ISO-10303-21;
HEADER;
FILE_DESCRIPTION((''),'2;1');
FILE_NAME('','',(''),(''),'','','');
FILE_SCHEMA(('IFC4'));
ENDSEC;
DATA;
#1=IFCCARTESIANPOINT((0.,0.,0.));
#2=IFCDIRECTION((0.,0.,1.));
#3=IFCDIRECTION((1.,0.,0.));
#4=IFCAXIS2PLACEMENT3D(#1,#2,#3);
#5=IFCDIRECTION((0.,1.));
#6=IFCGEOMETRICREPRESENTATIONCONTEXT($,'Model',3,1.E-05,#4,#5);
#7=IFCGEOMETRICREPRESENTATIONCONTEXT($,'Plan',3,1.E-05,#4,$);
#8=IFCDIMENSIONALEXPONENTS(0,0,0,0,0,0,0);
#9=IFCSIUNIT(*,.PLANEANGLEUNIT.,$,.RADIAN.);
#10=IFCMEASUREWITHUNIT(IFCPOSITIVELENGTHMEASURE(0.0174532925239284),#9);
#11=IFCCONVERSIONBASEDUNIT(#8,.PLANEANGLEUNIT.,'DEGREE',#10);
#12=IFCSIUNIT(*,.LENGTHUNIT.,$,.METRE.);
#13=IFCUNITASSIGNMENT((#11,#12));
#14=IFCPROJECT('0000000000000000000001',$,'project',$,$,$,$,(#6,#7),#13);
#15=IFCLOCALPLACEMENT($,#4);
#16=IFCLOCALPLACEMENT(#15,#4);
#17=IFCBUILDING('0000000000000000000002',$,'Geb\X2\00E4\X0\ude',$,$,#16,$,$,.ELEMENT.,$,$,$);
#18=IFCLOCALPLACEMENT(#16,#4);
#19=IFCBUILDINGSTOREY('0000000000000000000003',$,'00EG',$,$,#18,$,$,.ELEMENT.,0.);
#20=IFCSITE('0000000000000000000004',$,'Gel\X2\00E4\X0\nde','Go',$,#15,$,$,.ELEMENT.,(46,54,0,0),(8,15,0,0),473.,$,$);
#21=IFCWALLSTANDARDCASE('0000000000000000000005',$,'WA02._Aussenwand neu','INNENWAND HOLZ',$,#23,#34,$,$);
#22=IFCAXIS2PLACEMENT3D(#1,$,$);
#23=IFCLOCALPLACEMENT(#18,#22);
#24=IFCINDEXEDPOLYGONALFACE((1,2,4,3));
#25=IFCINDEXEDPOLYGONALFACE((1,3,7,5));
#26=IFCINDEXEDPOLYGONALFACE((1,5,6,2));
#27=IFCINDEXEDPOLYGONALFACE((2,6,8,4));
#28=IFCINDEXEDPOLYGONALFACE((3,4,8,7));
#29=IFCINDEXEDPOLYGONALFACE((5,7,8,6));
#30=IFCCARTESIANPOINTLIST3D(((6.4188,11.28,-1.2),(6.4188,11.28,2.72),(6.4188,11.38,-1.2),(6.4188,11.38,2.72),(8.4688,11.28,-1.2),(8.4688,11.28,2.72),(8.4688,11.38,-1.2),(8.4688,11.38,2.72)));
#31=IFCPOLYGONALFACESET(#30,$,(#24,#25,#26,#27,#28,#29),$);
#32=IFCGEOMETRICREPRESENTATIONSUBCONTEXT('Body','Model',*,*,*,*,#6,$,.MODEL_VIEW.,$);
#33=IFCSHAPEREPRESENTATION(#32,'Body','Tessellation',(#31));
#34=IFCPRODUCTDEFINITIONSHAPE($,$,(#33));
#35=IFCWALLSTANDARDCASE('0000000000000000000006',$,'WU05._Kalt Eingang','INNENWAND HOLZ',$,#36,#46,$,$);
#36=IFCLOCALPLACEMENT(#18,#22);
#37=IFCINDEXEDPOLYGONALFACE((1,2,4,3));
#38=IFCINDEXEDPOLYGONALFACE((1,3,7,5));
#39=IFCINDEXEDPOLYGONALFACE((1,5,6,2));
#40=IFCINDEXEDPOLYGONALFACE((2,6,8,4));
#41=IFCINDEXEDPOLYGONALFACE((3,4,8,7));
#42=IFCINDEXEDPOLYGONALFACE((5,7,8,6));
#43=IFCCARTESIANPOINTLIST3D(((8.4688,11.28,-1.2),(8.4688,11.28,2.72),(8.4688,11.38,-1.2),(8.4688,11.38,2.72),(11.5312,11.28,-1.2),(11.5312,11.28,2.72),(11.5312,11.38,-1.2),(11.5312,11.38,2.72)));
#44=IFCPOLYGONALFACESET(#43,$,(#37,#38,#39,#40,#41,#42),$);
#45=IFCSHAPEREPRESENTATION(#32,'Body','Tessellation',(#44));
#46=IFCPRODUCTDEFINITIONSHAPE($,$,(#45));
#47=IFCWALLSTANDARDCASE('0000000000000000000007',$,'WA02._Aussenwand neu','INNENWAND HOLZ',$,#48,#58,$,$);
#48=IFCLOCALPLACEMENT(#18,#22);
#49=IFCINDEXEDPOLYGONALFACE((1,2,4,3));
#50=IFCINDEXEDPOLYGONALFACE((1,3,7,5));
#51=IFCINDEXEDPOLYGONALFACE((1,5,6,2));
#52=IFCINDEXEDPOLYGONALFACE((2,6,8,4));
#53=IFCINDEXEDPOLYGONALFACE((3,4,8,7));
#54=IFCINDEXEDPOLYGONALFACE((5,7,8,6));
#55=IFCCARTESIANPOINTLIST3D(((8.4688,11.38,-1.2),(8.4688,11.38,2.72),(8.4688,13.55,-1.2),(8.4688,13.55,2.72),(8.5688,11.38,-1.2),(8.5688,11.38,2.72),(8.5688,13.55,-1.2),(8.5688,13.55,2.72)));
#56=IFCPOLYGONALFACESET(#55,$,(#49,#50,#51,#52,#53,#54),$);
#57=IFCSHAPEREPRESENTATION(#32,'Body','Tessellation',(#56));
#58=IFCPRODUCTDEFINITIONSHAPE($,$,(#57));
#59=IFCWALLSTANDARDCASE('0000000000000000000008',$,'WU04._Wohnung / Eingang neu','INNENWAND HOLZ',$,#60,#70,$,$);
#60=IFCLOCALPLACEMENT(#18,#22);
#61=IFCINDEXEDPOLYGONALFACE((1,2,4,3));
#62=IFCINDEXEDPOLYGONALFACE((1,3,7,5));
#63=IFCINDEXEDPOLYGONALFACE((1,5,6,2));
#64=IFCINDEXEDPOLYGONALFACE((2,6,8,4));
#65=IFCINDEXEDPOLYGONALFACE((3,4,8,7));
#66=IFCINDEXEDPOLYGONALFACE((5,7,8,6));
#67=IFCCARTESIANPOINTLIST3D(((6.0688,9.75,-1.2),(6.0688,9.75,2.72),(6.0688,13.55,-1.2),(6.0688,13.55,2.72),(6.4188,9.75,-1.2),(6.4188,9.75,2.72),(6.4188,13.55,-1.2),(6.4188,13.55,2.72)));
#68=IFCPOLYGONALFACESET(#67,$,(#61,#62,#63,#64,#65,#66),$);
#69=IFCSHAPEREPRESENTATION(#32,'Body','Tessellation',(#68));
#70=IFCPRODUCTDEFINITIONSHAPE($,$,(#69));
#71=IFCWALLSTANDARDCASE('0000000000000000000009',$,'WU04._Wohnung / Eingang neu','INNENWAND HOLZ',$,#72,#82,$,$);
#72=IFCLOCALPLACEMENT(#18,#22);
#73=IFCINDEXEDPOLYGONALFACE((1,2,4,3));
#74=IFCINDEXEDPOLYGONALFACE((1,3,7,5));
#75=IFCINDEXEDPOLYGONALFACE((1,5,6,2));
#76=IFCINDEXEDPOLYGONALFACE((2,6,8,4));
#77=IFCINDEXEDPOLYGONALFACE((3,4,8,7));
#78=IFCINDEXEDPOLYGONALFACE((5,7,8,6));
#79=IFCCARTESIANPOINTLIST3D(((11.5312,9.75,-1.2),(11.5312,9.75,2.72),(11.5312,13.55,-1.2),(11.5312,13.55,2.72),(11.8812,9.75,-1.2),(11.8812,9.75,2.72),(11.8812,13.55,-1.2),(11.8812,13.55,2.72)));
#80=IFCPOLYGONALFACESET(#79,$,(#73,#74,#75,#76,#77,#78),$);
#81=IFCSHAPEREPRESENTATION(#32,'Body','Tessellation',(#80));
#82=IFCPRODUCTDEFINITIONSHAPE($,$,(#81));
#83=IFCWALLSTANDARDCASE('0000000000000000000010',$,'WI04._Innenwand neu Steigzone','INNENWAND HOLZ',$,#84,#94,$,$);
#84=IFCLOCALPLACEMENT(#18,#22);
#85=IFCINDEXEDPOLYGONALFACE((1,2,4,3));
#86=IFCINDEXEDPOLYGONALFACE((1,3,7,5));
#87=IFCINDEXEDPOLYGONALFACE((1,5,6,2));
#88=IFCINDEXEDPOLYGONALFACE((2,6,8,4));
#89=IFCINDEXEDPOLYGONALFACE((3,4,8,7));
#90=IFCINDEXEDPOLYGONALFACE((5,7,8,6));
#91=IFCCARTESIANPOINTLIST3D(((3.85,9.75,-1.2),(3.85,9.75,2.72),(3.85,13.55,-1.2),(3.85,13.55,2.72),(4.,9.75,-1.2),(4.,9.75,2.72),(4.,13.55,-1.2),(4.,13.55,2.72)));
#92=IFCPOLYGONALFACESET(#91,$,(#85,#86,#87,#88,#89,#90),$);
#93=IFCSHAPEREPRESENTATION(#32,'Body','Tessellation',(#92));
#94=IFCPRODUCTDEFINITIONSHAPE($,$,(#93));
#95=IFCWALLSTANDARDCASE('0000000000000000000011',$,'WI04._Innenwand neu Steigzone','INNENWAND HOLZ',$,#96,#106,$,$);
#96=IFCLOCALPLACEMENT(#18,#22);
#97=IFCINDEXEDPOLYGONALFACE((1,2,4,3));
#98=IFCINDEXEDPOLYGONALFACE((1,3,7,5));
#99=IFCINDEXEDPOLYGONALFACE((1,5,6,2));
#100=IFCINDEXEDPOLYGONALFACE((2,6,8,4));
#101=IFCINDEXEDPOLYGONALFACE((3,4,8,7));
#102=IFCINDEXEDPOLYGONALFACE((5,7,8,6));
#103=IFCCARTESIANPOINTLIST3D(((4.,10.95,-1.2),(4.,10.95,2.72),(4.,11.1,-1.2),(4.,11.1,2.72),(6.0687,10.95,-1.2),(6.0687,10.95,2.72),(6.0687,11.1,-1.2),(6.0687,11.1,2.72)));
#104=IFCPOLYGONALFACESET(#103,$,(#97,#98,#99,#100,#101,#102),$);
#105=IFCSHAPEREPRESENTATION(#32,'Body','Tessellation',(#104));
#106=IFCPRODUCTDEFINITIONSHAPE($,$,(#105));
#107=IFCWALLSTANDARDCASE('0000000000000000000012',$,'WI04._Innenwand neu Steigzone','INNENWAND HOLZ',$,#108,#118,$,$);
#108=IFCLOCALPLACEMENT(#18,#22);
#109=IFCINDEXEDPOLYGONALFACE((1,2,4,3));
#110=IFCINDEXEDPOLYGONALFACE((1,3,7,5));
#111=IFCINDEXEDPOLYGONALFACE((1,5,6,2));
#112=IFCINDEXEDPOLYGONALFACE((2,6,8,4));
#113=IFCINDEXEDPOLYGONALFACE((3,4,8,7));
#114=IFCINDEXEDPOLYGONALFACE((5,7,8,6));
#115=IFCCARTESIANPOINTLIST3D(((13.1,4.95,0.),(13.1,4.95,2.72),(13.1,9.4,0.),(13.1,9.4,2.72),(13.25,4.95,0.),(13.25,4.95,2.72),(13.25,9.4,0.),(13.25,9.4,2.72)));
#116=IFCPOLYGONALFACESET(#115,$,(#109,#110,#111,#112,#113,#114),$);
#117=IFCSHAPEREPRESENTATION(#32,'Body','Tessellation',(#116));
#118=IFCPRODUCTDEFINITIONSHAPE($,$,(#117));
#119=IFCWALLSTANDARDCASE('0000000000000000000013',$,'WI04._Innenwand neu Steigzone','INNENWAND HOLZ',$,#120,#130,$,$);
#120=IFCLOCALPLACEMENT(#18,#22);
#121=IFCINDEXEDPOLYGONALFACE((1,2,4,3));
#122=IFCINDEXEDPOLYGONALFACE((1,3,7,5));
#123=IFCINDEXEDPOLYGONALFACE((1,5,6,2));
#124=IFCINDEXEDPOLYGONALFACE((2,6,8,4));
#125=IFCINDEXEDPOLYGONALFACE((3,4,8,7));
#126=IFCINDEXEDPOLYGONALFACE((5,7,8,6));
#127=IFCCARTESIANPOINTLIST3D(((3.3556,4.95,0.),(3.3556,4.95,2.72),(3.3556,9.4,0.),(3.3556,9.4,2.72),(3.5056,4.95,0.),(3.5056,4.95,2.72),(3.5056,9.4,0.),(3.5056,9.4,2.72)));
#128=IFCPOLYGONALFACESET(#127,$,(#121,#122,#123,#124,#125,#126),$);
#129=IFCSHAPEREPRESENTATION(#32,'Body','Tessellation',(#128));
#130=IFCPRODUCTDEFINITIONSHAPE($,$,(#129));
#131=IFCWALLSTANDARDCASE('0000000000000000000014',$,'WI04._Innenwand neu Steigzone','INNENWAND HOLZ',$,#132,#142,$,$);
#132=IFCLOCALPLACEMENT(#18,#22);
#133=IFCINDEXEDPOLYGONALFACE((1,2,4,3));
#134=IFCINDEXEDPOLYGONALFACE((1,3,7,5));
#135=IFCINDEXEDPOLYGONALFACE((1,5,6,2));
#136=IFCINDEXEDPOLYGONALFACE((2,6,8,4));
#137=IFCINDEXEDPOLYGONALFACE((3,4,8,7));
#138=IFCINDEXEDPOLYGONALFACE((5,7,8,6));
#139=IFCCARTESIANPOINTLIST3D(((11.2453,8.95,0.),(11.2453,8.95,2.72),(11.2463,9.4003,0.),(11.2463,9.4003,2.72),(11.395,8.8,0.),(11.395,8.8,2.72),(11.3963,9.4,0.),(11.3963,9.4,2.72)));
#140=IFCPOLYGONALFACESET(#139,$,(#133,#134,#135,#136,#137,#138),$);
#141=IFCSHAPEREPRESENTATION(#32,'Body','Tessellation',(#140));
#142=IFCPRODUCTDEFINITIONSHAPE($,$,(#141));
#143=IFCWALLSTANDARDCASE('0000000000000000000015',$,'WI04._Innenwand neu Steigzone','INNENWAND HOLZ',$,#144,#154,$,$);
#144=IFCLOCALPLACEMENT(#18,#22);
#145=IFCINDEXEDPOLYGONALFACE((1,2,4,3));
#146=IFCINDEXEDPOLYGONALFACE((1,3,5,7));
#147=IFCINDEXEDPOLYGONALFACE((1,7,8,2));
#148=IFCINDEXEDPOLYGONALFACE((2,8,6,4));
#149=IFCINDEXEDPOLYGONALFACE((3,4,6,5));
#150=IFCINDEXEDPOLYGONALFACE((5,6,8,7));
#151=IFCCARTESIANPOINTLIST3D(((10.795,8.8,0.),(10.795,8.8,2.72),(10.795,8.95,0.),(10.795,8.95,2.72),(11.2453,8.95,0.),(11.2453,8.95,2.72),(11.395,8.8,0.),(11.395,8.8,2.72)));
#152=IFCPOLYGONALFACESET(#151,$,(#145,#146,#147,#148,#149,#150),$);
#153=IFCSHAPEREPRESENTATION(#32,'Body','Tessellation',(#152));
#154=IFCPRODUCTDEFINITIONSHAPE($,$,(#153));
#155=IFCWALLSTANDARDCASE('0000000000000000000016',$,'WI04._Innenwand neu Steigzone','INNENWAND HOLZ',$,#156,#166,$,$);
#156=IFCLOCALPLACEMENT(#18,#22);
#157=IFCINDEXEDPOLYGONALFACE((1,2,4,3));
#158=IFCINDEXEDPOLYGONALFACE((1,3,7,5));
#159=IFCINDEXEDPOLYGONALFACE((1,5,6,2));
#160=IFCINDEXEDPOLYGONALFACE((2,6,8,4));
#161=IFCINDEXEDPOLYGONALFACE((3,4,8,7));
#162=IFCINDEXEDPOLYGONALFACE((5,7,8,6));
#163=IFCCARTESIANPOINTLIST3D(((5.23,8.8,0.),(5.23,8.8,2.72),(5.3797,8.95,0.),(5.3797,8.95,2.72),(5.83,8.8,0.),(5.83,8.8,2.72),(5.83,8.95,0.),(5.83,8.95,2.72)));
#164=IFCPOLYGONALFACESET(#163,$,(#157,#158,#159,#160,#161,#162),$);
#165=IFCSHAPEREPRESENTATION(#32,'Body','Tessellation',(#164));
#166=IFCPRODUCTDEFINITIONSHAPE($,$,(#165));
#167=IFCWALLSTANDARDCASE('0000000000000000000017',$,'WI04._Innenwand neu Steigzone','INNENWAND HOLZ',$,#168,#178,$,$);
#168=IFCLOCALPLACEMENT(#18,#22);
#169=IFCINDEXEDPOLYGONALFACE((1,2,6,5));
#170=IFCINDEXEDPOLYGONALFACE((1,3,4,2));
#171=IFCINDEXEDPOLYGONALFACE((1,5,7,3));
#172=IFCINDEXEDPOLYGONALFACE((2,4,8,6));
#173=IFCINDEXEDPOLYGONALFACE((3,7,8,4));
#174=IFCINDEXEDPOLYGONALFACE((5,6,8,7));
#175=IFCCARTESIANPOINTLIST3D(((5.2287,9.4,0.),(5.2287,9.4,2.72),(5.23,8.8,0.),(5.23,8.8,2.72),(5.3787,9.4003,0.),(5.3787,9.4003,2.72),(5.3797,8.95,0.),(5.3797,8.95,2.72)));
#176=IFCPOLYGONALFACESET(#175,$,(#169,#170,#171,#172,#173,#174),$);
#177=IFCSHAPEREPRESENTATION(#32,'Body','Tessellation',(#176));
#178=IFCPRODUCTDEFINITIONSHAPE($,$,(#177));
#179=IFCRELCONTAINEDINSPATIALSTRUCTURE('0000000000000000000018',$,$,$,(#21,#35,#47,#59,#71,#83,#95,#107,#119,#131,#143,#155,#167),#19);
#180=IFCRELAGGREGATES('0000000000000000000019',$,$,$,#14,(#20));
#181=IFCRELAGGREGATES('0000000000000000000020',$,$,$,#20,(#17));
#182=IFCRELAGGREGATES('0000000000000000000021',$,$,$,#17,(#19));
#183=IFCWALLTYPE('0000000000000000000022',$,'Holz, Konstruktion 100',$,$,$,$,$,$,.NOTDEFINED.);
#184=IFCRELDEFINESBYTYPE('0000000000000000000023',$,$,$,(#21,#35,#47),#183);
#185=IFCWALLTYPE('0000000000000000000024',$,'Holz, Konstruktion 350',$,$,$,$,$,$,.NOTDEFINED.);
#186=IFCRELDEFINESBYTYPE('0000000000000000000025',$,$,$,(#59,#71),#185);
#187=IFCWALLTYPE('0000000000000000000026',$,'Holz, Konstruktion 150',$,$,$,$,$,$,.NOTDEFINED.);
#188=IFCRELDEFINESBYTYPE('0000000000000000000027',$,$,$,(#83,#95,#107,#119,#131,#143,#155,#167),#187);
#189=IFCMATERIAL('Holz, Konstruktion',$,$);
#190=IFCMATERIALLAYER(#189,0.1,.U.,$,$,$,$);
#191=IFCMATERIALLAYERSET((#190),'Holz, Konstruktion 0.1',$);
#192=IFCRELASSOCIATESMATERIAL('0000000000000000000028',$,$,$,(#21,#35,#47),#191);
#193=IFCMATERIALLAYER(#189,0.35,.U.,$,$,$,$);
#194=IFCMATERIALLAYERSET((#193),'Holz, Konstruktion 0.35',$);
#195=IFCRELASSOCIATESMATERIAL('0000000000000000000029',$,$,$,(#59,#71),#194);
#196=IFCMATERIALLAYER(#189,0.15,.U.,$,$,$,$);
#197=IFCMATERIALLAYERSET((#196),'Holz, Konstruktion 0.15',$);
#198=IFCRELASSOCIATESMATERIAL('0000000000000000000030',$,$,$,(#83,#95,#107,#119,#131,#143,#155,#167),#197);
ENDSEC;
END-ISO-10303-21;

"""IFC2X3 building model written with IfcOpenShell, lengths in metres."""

from ifc_helpers import new_model, entity, si_unit, converted_unit, direction, frame, origin_with_axes, place, context, subcontext, project, spatial, polyline, outline, extrude, material, layer, layer_set, layer_usage, type_object, element, save


model = new_model("IFC2X3")

# Units and contexts
model_context = context("Model", 3, precision=1e-05, world=origin_with_axes(), true_north=direction((0.0, 1.0)))
plan_context = context("Plan", 3, precision=1e-05, world=origin_with_axes())
body_context = subcontext(model_context, "Body", "Model", "MODEL_VIEW")
ifc_project = project(units=[converted_unit("PLANEANGLEUNIT", "DEGREE", entity("IfcPositiveLengthMeasure", 0.0174532925239284), si_unit("PLANEANGLEUNIT", "RADIAN"), dimensions=[0, 0, 0, 0, 0, 0, 0]), si_unit("LENGTHUNIT", "METRE")], contexts=[model_context, plan_context])

# Site, building, storey
site_placement = place(None, origin_with_axes())
site = spatial("IfcSite", under=ifc_project, at=site_placement, Name="Gelände", Description="Go", CompositionType="ELEMENT", RefLatitude=(46, 54, 0, 0), RefLongitude=(8, 15, 0, 0), RefElevation=473.0)
building_placement = place(site_placement, origin_with_axes())
building = spatial("IfcBuilding", under=site, at=building_placement, Name="Gebäude", CompositionType="ELEMENT")
storey_placement = place(building_placement, origin_with_axes())
storey = spatial("IfcBuildingStorey", under=building, at=storey_placement, Name="00EG", CompositionType="ELEMENT", Elevation=0.0)

# Shared definitions
ifc_material_1 = material(Name="Holz, Konstruktion")

# Walls
ifc_layer_1 = layer(ifc_material_1, 0.1, ventilated="UNKNOWN")
ifc_layer_set_1 = layer_set([ifc_layer_1], Name="Holz, Konstruktion 0.1")
ifc_layer_usage_1 = layer_usage(ifc_layer_set_1, "AXIS2", "POSITIVE", 0.0)
wall_type_1 = type_object("IfcWallType", Name="Holz, Konstruktion 100", PredefinedType="NOTDEFINED")
wall_1_placement = place(storey_placement, frame((6.4188, 11.28, -1.2), z_axis=(0.0, 0.0, 1.0), x_axis=(1.0, 0.0, 0.0)))
element("IfcWallStandardCase", 1, at=wall_1_placement, inside=storey, type_object=wall_type_1, material=ifc_layer_usage_1, Name="WA02._Aussenwand neu", Description="INNENWAND HOLZ", context=body_context, shape_type="SweptSolid", body=[
    extrude(outline(polyline([(0.0, 0.0), (2.05, 0.0), (2.05, 0.1), (0.0, 0.1), (0.0, 0.0)])), origin_with_axes(), (0.0, 0.0, 1.0), 3.92),
])
ifc_layer_usage_2 = layer_usage(ifc_layer_set_1, "AXIS2", "POSITIVE", 0.0)
wall_2_placement = place(storey_placement, frame((8.4688, 11.28, -1.2), z_axis=(0.0, 0.0, 1.0), x_axis=(1.0, 0.0, 0.0)))
element("IfcWallStandardCase", 2, at=wall_2_placement, inside=storey, type_object=wall_type_1, material=ifc_layer_usage_2, Name="WU05._Kalt Eingang", Description="INNENWAND HOLZ", context=body_context, shape_type="SweptSolid", body=[
    extrude(outline(polyline([(0.0, 0.0), (3.0625, 0.0), (3.0625, 0.1), (0.0, 0.1), (0.0, 0.0)])), origin_with_axes(), (0.0, 0.0, 1.0), 3.92),
])
ifc_layer_usage_3 = layer_usage(ifc_layer_set_1, "AXIS2", "POSITIVE", 0.0)
wall_3_placement = place(storey_placement, frame((8.4688, 13.55, -1.2), z_axis=(0.0, 0.0, 1.0), x_axis=(0.0, -1.0, 0.0)))
element("IfcWallStandardCase", 3, at=wall_3_placement, inside=storey, type_object=wall_type_1, material=ifc_layer_usage_3, Name="WA02._Aussenwand neu", Description="INNENWAND HOLZ", context=body_context, shape_type="SweptSolid", body=[
    extrude(outline(polyline([(0.0, 0.0), (2.17, 0.0), (2.17, 0.1), (0.0, 0.1), (0.0, 0.0)])), origin_with_axes(), (0.0, 0.0, 1.0), 3.92),
])
ifc_layer_2 = layer(ifc_material_1, 0.35, ventilated="UNKNOWN")
ifc_layer_set_2 = layer_set([ifc_layer_2], Name="Holz, Konstruktion 0.35")
ifc_layer_usage_4 = layer_usage(ifc_layer_set_2, "AXIS2", "NEGATIVE", 0.0)
wall_type_2 = type_object("IfcWallType", Name="Holz, Konstruktion 350", PredefinedType="NOTDEFINED")
wall_4_placement = place(storey_placement, frame((6.4188, 13.55, -1.2), z_axis=(0.0, 0.0, 1.0), x_axis=(0.0, -1.0, 0.0)))
element("IfcWallStandardCase", 4, at=wall_4_placement, inside=storey, type_object=wall_type_2, material=ifc_layer_usage_4, Name="WU04._Wohnung / Eingang neu", Description="INNENWAND HOLZ", context=body_context, shape_type="SweptSolid", body=[
    extrude(outline(polyline([(0.0, -0.35), (3.8, -0.35), (3.8, 0.0), (0.0, 0.0), (0.0, -0.35)])), origin_with_axes(), (0.0, 0.0, 1.0), 3.92),
])
ifc_layer_usage_5 = layer_usage(ifc_layer_set_2, "AXIS2", "NEGATIVE", 0.0)
wall_5_placement = place(storey_placement, frame((11.8812, 13.55, -1.2), z_axis=(0.0, 0.0, 1.0), x_axis=(0.0, -1.0, 0.0)))
element("IfcWallStandardCase", 5, at=wall_5_placement, inside=storey, type_object=wall_type_2, material=ifc_layer_usage_5, Name="WU04._Wohnung / Eingang neu", Description="INNENWAND HOLZ", context=body_context, shape_type="SweptSolid", body=[
    extrude(outline(polyline([(0.0, -0.35), (3.8, -0.35), (3.8, 0.0), (0.0, 0.0), (0.0, -0.35)])), origin_with_axes(), (0.0, 0.0, 1.0), 3.92),
])
ifc_layer_3 = layer(ifc_material_1, 0.15, ventilated="UNKNOWN")
ifc_layer_set_3 = layer_set([ifc_layer_3], Name="Holz, Konstruktion 0.15")
ifc_layer_usage_6 = layer_usage(ifc_layer_set_3, "AXIS2", "NEGATIVE", 0.0)
wall_type_3 = type_object("IfcWallType", Name="Holz, Konstruktion 150", PredefinedType="NOTDEFINED")
wall_6_placement = place(storey_placement, frame((4.0, 13.55, -1.2), z_axis=(0.0, 0.0, 1.0), x_axis=(0.0, -1.0, 0.0)))
element("IfcWallStandardCase", 6, at=wall_6_placement, inside=storey, type_object=wall_type_3, material=ifc_layer_usage_6, Name="WI04._Innenwand neu Steigzone", Description="INNENWAND HOLZ", context=body_context, shape_type="SweptSolid", body=[
    extrude(outline(polyline([(0.0, -0.15), (3.8, -0.15), (3.8, 0.0), (0.0, 0.0), (0.0, -0.15)])), origin_with_axes(), (0.0, 0.0, 1.0), 3.92),
])
ifc_layer_usage_7 = layer_usage(ifc_layer_set_3, "AXIS2", "NEGATIVE", 0.0)
wall_7_placement = place(storey_placement, frame((6.0687, 10.95, -1.2), z_axis=(0.0, 0.0, 1.0), x_axis=(-1.0, 0.0, 0.0)))
element("IfcWallStandardCase", 7, at=wall_7_placement, inside=storey, type_object=wall_type_3, material=ifc_layer_usage_7, Name="WI04._Innenwand neu Steigzone", Description="INNENWAND HOLZ", context=body_context, shape_type="SweptSolid", body=[
    extrude(outline(polyline([(0.0, -0.15), (2.0687, -0.15), (2.0687, 0.0), (0.0, 0.0), (0.0, -0.15)])), origin_with_axes(), (0.0, 0.0, 1.0), 3.92),
])
ifc_layer_usage_8 = layer_usage(ifc_layer_set_3, "AXIS2", "POSITIVE", 0.0)
wall_8_placement = place(storey_placement, frame((13.1, 9.4, 0.0), z_axis=(0.0, 0.0, 1.0), x_axis=(0.0, -1.0, 0.0)))
element("IfcWallStandardCase", 8, at=wall_8_placement, inside=storey, type_object=wall_type_3, material=ifc_layer_usage_8, Name="WI04._Innenwand neu Steigzone", Description="INNENWAND HOLZ", context=body_context, shape_type="SweptSolid", body=[
    extrude(outline(polyline([(0.0, 0.0), (4.45, 0.0), (4.45, 0.15), (0.0, 0.15), (0.0, 0.0)])), origin_with_axes(), (0.0, 0.0, 1.0), 2.72),
])
ifc_layer_usage_9 = layer_usage(ifc_layer_set_3, "AXIS2", "NEGATIVE", 0.0)
wall_9_placement = place(storey_placement, frame((3.5056, 9.4, 0.0), z_axis=(0.0, 0.0, 1.0), x_axis=(0.0, -1.0, 0.0)))
element("IfcWallStandardCase", 9, at=wall_9_placement, inside=storey, type_object=wall_type_3, material=ifc_layer_usage_9, Name="WI04._Innenwand neu Steigzone", Description="INNENWAND HOLZ", context=body_context, shape_type="SweptSolid", body=[
    extrude(outline(polyline([(0.0, -0.15), (4.45, -0.15), (4.45, 0.0), (0.0, 0.0), (0.0, -0.15)])), origin_with_axes(), (0.0, 0.0, 1.0), 2.72),
])
ifc_layer_usage_10 = layer_usage(ifc_layer_set_3, "AXIS2", "NEGATIVE", 0.0)
wall_10_placement = place(storey_placement, frame((11.3963, 9.4, 0.0), z_axis=(0.0, 0.0, 1.0), x_axis=(-0.002118, -0.999998, 0.0)))
element("IfcWallStandardCase", 10, at=wall_10_placement, inside=storey, type_object=wall_type_3, material=ifc_layer_usage_10, Name="WI04._Innenwand neu Steigzone", Description="INNENWAND HOLZ", context=body_context, shape_type="SweptSolid", body=[
    extrude(outline(polyline([(0.0, -0.15), (0.4503, -0.15), (0.6, 0.0), (0.0, 0.0), (0.0, -0.15)])), origin_with_axes(), (0.0, 0.0, 1.0), 2.72),
])
ifc_layer_usage_11 = layer_usage(ifc_layer_set_3, "AXIS2", "NEGATIVE", 0.0)
wall_11_placement = place(storey_placement, frame((11.395, 8.8, 0.0), z_axis=(0.0, 0.0, 1.0), x_axis=(-1.0, 0.0, 0.0)))
element("IfcWallStandardCase", 11, at=wall_11_placement, inside=storey, type_object=wall_type_3, material=ifc_layer_usage_11, Name="WI04._Innenwand neu Steigzone", Description="INNENWAND HOLZ", context=body_context, shape_type="SweptSolid", body=[
    extrude(outline(polyline([(0.1497, -0.15), (0.6, -0.15), (0.6, 0.0), (0.0, 0.0), (0.1497, -0.15)])), origin_with_axes(), (0.0, 0.0, 1.0), 2.72),
])
ifc_layer_usage_12 = layer_usage(ifc_layer_set_3, "AXIS2", "POSITIVE", 0.0)
wall_12_placement = place(storey_placement, frame((5.23, 8.8, 0.0), z_axis=(0.0, 0.0, 1.0), x_axis=(1.0, 0.0, 0.0)))
element("IfcWallStandardCase", 12, at=wall_12_placement, inside=storey, type_object=wall_type_3, material=ifc_layer_usage_12, Name="WI04._Innenwand neu Steigzone", Description="INNENWAND HOLZ", context=body_context, shape_type="SweptSolid", body=[
    extrude(outline(polyline([(0.0, 0.0), (0.6, 0.0), (0.6, 0.15), (0.1497, 0.15), (0.0, 0.0)])), origin_with_axes(), (0.0, 0.0, 1.0), 2.72),
])
ifc_layer_usage_13 = layer_usage(ifc_layer_set_3, "AXIS2", "POSITIVE", 0.0)
wall_13_placement = place(storey_placement, frame((5.2287, 9.4, 0.0), z_axis=(0.0, 0.0, 1.0), x_axis=(0.002118, -0.999998, 0.0)))
element("IfcWallStandardCase", 13, at=wall_13_placement, inside=storey, type_object=wall_type_3, material=ifc_layer_usage_13, Name="WI04._Innenwand neu Steigzone", Description="INNENWAND HOLZ", context=body_context, shape_type="SweptSolid", body=[
    extrude(outline(polyline([(0.0, 0.0), (0.6, 0.0), (0.4503, 0.15), (0.0, 0.15), (0.0, 0.0)])), origin_with_axes(), (0.0, 0.0, 1.0), 2.72),
])

save(model, "model.ifc")
